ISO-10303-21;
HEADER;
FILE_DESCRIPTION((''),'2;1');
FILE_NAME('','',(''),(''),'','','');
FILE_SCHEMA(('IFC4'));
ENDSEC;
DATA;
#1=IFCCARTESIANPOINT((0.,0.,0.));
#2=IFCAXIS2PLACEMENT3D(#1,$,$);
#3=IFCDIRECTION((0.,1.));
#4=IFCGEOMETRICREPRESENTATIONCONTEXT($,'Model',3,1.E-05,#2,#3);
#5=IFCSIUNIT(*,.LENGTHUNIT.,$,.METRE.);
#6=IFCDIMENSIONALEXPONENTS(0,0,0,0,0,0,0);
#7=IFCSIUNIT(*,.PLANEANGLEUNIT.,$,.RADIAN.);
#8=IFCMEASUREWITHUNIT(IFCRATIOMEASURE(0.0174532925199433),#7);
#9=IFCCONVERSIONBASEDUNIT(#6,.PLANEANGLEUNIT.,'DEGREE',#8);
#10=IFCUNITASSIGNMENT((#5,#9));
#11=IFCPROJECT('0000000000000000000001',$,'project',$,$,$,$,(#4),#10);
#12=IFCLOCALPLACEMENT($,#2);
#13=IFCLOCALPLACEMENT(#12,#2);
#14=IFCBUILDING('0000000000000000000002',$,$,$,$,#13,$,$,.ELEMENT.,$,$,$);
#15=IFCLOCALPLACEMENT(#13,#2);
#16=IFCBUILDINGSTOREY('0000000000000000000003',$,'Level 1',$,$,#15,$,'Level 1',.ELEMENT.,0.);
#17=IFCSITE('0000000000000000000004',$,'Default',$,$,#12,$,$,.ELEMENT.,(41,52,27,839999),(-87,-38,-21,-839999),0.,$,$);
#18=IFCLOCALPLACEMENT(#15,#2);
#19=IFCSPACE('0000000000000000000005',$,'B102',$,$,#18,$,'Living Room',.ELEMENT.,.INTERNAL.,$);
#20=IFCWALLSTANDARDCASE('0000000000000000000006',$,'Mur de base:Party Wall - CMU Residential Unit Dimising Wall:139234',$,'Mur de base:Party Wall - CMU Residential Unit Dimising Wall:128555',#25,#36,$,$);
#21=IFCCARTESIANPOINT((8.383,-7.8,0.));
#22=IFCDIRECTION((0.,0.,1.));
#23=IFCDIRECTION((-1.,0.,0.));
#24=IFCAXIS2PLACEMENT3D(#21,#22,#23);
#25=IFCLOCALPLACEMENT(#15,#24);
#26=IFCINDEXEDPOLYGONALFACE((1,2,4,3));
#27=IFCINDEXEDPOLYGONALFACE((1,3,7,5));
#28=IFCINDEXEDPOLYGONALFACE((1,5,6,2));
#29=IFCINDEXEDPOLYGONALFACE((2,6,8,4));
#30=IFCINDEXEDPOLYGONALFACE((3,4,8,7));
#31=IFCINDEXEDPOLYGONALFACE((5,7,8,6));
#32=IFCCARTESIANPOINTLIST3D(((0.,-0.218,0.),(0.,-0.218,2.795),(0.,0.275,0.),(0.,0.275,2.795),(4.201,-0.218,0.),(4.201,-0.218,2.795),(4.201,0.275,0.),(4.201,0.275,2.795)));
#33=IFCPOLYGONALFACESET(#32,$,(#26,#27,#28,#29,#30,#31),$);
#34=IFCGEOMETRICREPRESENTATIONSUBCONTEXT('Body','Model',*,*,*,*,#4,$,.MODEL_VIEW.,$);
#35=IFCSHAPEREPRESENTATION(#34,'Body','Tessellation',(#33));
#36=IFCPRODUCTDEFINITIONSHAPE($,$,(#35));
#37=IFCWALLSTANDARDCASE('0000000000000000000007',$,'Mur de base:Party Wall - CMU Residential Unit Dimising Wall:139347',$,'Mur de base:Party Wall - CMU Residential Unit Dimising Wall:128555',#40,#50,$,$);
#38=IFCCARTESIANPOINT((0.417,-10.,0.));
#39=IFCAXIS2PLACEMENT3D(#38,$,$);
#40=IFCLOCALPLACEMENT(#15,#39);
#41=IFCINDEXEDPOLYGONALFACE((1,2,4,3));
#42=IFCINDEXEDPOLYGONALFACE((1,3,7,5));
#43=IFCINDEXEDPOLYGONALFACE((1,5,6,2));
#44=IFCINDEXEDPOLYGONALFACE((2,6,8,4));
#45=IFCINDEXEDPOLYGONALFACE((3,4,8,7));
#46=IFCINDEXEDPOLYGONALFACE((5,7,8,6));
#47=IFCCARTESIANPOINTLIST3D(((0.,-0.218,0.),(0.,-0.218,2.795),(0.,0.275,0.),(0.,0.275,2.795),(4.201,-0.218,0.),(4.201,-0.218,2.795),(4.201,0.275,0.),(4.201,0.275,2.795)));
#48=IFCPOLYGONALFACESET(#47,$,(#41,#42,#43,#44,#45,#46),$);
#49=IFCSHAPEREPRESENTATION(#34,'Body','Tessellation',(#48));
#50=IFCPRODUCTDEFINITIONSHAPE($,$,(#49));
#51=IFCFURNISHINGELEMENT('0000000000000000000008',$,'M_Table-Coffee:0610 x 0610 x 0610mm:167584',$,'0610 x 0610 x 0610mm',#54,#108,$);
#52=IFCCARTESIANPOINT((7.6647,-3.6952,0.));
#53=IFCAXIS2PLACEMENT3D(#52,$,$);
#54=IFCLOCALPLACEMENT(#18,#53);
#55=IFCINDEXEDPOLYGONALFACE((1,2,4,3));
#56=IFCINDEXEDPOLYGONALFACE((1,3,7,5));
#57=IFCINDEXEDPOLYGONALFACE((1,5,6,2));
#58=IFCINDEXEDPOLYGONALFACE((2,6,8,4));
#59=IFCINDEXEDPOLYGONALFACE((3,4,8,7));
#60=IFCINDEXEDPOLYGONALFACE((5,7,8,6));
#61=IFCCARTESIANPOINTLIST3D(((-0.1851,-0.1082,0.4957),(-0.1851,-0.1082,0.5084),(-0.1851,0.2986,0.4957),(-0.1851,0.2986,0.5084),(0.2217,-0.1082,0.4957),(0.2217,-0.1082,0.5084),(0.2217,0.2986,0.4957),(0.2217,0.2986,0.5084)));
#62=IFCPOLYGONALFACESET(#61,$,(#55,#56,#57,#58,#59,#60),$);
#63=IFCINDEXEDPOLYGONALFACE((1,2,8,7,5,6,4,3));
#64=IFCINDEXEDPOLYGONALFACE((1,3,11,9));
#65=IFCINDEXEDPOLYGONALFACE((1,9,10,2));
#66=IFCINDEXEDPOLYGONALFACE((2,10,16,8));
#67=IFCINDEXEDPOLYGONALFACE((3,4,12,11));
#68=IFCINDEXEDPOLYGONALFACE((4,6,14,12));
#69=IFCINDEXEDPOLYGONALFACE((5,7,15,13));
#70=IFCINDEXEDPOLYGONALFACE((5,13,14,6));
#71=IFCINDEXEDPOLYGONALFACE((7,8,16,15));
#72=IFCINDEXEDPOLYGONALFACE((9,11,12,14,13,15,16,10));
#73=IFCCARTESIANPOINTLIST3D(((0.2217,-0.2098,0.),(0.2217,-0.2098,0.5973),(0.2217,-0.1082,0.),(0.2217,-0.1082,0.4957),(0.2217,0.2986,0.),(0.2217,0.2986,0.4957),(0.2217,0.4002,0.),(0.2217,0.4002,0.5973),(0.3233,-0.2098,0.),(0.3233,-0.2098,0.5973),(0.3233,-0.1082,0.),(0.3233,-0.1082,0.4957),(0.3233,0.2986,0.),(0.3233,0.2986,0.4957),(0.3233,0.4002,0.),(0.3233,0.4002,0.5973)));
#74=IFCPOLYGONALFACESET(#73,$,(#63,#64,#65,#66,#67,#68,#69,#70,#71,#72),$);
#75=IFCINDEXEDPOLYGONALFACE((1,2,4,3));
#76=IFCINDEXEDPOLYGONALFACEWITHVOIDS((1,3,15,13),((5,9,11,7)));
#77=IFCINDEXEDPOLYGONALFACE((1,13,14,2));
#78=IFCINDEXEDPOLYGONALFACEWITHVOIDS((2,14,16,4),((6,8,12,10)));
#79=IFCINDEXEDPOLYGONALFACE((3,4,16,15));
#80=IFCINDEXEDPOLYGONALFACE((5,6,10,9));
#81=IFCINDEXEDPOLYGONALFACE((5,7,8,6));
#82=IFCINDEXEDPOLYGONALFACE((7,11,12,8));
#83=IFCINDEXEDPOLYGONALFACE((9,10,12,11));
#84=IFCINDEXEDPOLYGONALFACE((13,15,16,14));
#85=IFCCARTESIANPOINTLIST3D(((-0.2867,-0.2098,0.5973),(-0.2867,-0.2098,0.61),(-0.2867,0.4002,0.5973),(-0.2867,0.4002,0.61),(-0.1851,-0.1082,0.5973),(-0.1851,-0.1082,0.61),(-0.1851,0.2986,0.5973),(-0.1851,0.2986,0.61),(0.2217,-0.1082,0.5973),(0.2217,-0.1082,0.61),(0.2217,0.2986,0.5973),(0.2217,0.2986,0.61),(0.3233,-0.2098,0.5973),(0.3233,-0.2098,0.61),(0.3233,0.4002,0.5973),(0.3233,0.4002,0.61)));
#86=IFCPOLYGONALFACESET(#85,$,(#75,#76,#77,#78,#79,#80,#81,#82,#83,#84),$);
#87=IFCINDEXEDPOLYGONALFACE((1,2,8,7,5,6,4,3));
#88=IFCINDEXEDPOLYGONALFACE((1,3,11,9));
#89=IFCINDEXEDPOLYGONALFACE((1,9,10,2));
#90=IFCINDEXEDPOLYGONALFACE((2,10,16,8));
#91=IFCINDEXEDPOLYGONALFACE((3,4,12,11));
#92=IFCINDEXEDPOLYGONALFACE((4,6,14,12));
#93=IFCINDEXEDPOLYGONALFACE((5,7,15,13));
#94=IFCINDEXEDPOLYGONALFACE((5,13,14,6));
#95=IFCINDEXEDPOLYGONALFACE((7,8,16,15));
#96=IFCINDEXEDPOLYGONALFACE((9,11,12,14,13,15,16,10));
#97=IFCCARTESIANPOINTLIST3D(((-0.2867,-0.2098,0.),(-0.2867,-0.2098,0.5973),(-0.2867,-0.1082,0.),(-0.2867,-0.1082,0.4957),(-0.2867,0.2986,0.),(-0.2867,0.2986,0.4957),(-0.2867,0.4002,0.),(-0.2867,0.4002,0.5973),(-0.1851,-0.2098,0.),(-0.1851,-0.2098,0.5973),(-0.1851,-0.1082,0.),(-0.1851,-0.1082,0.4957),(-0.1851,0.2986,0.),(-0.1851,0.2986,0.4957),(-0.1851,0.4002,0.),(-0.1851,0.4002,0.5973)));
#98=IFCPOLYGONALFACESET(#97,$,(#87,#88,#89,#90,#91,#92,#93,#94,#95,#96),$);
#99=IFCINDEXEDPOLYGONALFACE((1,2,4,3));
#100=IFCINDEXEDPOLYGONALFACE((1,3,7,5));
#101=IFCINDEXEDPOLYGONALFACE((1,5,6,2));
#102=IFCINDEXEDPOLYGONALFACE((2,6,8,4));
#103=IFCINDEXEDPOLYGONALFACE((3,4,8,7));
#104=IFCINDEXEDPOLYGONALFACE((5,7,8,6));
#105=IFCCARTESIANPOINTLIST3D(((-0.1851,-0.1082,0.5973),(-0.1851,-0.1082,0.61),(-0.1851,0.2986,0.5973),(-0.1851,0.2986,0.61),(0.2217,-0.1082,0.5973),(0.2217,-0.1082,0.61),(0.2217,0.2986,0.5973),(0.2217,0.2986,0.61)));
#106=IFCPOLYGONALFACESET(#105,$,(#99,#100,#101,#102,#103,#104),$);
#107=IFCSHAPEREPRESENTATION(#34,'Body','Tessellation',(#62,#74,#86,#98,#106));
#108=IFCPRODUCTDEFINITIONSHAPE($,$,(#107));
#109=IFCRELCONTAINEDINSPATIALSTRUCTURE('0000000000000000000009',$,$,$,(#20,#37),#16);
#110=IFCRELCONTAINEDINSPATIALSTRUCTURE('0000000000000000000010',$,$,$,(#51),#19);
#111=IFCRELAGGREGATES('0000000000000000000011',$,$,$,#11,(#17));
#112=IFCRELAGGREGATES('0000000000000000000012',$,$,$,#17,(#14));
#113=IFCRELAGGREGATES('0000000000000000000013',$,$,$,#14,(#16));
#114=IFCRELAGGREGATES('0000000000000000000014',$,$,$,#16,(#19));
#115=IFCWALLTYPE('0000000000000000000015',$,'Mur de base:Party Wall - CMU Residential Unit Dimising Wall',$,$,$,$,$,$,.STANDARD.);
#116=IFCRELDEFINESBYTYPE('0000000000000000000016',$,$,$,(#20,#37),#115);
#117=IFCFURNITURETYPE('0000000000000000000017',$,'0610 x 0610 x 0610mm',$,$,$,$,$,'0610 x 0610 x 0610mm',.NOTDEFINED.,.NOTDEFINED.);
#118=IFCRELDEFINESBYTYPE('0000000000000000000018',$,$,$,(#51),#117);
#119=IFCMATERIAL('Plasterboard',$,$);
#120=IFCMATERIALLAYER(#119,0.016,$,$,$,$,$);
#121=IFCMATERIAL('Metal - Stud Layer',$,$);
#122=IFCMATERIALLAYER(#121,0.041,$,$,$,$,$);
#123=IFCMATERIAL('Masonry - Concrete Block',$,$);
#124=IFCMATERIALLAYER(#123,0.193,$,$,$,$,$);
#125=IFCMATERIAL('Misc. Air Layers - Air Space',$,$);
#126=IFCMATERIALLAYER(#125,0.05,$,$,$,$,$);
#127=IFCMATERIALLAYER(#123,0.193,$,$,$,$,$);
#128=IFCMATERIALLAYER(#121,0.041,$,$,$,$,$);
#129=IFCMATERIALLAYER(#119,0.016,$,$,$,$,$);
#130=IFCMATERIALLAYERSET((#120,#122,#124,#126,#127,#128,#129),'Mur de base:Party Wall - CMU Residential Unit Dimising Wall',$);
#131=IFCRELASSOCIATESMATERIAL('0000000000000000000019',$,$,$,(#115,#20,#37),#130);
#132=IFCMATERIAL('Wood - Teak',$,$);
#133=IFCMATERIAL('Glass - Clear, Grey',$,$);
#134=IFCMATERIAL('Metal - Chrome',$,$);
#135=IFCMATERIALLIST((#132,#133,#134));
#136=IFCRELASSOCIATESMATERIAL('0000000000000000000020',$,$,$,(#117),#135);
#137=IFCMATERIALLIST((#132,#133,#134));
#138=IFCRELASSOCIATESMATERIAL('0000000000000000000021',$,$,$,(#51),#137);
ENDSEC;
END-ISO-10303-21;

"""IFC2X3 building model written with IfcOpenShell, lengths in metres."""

from ifc_helpers import new_model, entity, si_unit, converted_unit, direction, frame, frame_2d, origin, origin_2d_with_axis, place, context, subcontext, project, spatial, polyline, rectangle, outline, extrude, clip, bounded_halfspace, source, transform, mapped, material, material_list, layer, layer_set, layer_usage, type_object, type_shapes, element, save


model = new_model("IFC2X3")

# Units and contexts
model_context = context("Model", 3, precision=1e-05, world=origin(), true_north=direction((0.0, 1.0)))
body_context = subcontext(model_context, "Body", "Model", "MODEL_VIEW")
ifc_project = project(units=[si_unit("LENGTHUNIT", "METRE"), converted_unit("PLANEANGLEUNIT", "DEGREE", entity("IfcRatioMeasure", 0.0174532925199433), si_unit("PLANEANGLEUNIT", "RADIAN"), dimensions=[0, 0, 0, 0, 0, 0, 0])], contexts=[model_context])

# Site, building, storey
site_placement = place(None, origin())
site = spatial("IfcSite", under=ifc_project, at=site_placement, Name="Default", CompositionType="ELEMENT", RefLatitude=(41, 52, 27, 839999), RefLongitude=(-87, -38, -21, -839999), RefElevation=0.0)
building_placement = place(site_placement, origin())
building = spatial("IfcBuilding", under=site, at=building_placement, CompositionType="ELEMENT")
storey_placement = place(building_placement, origin())
storey = spatial("IfcBuildingStorey", under=building, at=storey_placement, Name="Level 1", LongName="Level 1", CompositionType="ELEMENT", Elevation=0.0)

# Shared definitions
ifc_material_1 = material(Name="Plasterboard")
ifc_material_2 = material(Name="Metal - Stud Layer")

# Walls
ifc_layer_1 = layer(ifc_material_1, 0.016)
ifc_layer_2 = layer(ifc_material_2, 0.041)
ifc_material_3 = material(Name="Masonry - Concrete Block")
ifc_layer_3 = layer(ifc_material_3, 0.193)
ifc_material_4 = material(Name="Misc. Air Layers - Air Space")
ifc_layer_4 = layer(ifc_material_4, 0.05)
ifc_layer_5 = layer(ifc_material_3, 0.193)
ifc_layer_6 = layer(ifc_material_2, 0.041)
ifc_layer_7 = layer(ifc_material_1, 0.016)
ifc_layer_set_1 = layer_set([ifc_layer_1, ifc_layer_2, ifc_layer_3, ifc_layer_4, ifc_layer_5, ifc_layer_6, ifc_layer_7], Name="Mur de base:Party Wall - CMU Residential Unit Dimising Wall")
ifc_layer_usage_1 = layer_usage(ifc_layer_set_1, "AXIS2", "NEGATIVE", 0.275)
wall_type_1 = type_object("IfcWallType", Name="Mur de base:Party Wall - CMU Residential Unit Dimising Wall", PredefinedType="STANDARD", material=ifc_layer_set_1)
wall_1_placement = place(storey_placement, frame((8.383, -7.8, 0.0), z_axis=(0.0, 0.0, 1.0), x_axis=(-1.0, 0.0, 0.0)))
element("IfcWallStandardCase", 1, at=wall_1_placement, inside=storey, type_object=wall_type_1, material=ifc_layer_usage_1, Name="Mur de base:Party Wall - CMU Residential Unit Dimising Wall:139234", ObjectType="Mur de base:Party Wall - CMU Residential Unit Dimising Wall:128555", context=body_context, shape_type="Clipping", body=[
    clip(clip(extrude(rectangle(XDim=4.201, YDim=0.55, at=frame_2d((2.1005, 0.0), x_axis=(-1.0, 0.0))), origin(), (0.0, 0.0, 1.0), 2.795), bounded_halfspace(frame((0.0, -0.218, 2.795), z_axis=(0.0, 1.0, 0.0), x_axis=(-1.0, 0.0, 0.0)), True, frame((0.0, -0.218, 2.795), z_axis=(0.0, 1.0, 0.0), x_axis=(-1.0, 0.0, 0.0)), polyline([(0.0, 0.0), (-3.708, 0.0), (-4.201, 0.0), (-4.201, -2.795), (0.0, -2.795), (0.0, 0.0)]))), bounded_halfspace(frame((4.201, 0.275, 0.0), z_axis=(-1.0, 0.0, 0.0), x_axis=(0.0, -1.0, 0.0)), True, frame((4.201, 0.275, 0.0), z_axis=(-1.0, 0.0, 0.0), x_axis=(0.0, -1.0, 0.0)), polyline([(0.0, 0.0), (0.493, 0.0), (0.493, 2.795), (0.0, 2.795), (0.0, 0.0)]))),
])
ifc_layer_usage_2 = layer_usage(ifc_layer_set_1, "AXIS2", "NEGATIVE", 0.275)
wall_2_placement = place(storey_placement, frame((0.417, -10.0, 0.0)))
element("IfcWallStandardCase", 2, at=wall_2_placement, inside=storey, type_object=wall_type_1, material=ifc_layer_usage_2, Name="Mur de base:Party Wall - CMU Residential Unit Dimising Wall:139347", ObjectType="Mur de base:Party Wall - CMU Residential Unit Dimising Wall:128555", context=body_context, shape_type="Clipping", body=[
    clip(clip(extrude(rectangle(XDim=4.201, YDim=0.55, at=frame_2d((2.1005, 0.0), x_axis=(-1.0, 0.0))), origin(), (0.0, 0.0, 1.0), 2.795), bounded_halfspace(frame((0.0, -0.218, 0.0), z_axis=(0.0, 1.0, 0.0), x_axis=(-1.0, 0.0, 0.0)), True, frame((0.0, -0.218, 0.0), z_axis=(0.0, 1.0, 0.0), x_axis=(-1.0, 0.0, 0.0)), polyline([(0.0, 0.0), (0.0, 2.795), (-4.201, 2.795), (-4.201, 0.0), (0.0, 0.0)]))), bounded_halfspace(frame((4.201, 0.275, 0.0), z_axis=(-1.0, 0.0, 0.0), x_axis=(0.0, -1.0, 0.0)), True, frame((4.201, 0.275, 0.0), z_axis=(-1.0, 0.0, 0.0), x_axis=(0.0, -1.0, 0.0)), polyline([(0.0, 0.0), (0.493, 0.0), (0.493, 2.795), (0.0, 2.795), (0.0, 0.0)]))),
])

# Shared definitions
space_1_placement = place(storey_placement, origin())
space_1 = spatial("IfcSpace", under=storey, at=space_1_placement, Name="B102", LongName="Living Room", CompositionType="ELEMENT", InteriorOrExteriorSpace="INTERNAL")

# Furnishing element
ifc_material_5 = material(Name="Wood - Teak")
ifc_material_6 = material(Name="Glass - Clear, Grey")
ifc_material_7 = material(Name="Metal - Chrome")
ifc_material_list_1 = material_list([ifc_material_5, ifc_material_6, ifc_material_7])
ifc_material_list_2 = material_list([ifc_material_5, ifc_material_6, ifc_material_7])
furniture_type_1 = type_object("IfcFurnitureType", Name="0610 x 0610 x 0610mm", ElementType="0610 x 0610 x 0610mm", AssemblyPlace="NOTDEFINED", material=ifc_material_list_2)
shared_shape_1 = source(origin(), body_context, "Body", "SweptSolid", [
    extrude(rectangle(XDim=0.4068, YDim=0.4068, at=origin_2d_with_axis()), frame((0.0183, 0.0952, 0.4957), z_axis=(0.0, 0.0, 1.0), x_axis=(-1.0, 0.0, 0.0)), (0.0, 0.0, 1.0), 0.0127),
    extrude(outline(polyline([(-0.2732, -0.305), (0.324, -0.305), (0.324, 0.305), (-0.2732, 0.305), (-0.2732, 0.2034), (0.2225, 0.2034), (0.2225, -0.2034), (-0.2732, -0.2034), (-0.2732, -0.305)])), frame((0.2217, 0.0952, 0.2732), z_axis=(1.0, 0.0, 0.0), x_axis=(0.0, 0.0, 1.0)), (0.0, 0.0, 1.0), 0.1016),
    extrude(outline(polyline([(-0.305, -0.305), (0.305, -0.305), (0.305, 0.305), (-0.305, 0.305), (-0.305, -0.305)]), holes=[polyline([(-0.2034, -0.2034), (-0.2034, 0.2034), (0.2034, 0.2034), (0.2034, -0.2034), (-0.2034, -0.2034)])]), frame((0.0183, 0.0952, 0.5973), z_axis=(0.0, 0.0, 1.0), x_axis=(-1.0, 0.0, 0.0)), (0.0, 0.0, 1.0), 0.0127),
    extrude(outline(polyline([(-0.305, -0.3241), (0.305, -0.3241), (0.305, 0.2733), (0.2034, 0.2733), (0.2034, -0.2224), (-0.2034, -0.2224), (-0.2034, 0.2733), (-0.305, 0.2733), (-0.305, -0.3241)])), frame((-0.2867, 0.0952, 0.2733), z_axis=(1.0, 0.0, 0.0), x_axis=(0.0, -1.0, 0.0)), (0.0, 0.0, 1.0), 0.1016),
    extrude(rectangle(XDim=0.4068, YDim=0.4068, at=origin_2d_with_axis()), frame((0.0183, 0.0952, 0.5973), z_axis=(0.0, 0.0, 1.0), x_axis=(-1.0, 0.0, 0.0)), (0.0, 0.0, 1.0), 0.0127),
])
type_shapes(furniture_type_1, [shared_shape_1])
furnishing_1_placement = place(space_1_placement, frame((7.6647, -3.6952, 0.0)))
element("IfcFurnishingElement", 3, at=furnishing_1_placement, inside=space_1, type_object=furniture_type_1, material=ifc_material_list_1, Name="M_Table-Coffee:0610 x 0610 x 0610mm:167584", ObjectType="0610 x 0610 x 0610mm", context=body_context, shape_type="MappedRepresentation", body=[
    mapped(shared_shape_1, transform((0.0, 0.0, 0.0), scale=1.0)),
])

save(model, "model.ifc")
